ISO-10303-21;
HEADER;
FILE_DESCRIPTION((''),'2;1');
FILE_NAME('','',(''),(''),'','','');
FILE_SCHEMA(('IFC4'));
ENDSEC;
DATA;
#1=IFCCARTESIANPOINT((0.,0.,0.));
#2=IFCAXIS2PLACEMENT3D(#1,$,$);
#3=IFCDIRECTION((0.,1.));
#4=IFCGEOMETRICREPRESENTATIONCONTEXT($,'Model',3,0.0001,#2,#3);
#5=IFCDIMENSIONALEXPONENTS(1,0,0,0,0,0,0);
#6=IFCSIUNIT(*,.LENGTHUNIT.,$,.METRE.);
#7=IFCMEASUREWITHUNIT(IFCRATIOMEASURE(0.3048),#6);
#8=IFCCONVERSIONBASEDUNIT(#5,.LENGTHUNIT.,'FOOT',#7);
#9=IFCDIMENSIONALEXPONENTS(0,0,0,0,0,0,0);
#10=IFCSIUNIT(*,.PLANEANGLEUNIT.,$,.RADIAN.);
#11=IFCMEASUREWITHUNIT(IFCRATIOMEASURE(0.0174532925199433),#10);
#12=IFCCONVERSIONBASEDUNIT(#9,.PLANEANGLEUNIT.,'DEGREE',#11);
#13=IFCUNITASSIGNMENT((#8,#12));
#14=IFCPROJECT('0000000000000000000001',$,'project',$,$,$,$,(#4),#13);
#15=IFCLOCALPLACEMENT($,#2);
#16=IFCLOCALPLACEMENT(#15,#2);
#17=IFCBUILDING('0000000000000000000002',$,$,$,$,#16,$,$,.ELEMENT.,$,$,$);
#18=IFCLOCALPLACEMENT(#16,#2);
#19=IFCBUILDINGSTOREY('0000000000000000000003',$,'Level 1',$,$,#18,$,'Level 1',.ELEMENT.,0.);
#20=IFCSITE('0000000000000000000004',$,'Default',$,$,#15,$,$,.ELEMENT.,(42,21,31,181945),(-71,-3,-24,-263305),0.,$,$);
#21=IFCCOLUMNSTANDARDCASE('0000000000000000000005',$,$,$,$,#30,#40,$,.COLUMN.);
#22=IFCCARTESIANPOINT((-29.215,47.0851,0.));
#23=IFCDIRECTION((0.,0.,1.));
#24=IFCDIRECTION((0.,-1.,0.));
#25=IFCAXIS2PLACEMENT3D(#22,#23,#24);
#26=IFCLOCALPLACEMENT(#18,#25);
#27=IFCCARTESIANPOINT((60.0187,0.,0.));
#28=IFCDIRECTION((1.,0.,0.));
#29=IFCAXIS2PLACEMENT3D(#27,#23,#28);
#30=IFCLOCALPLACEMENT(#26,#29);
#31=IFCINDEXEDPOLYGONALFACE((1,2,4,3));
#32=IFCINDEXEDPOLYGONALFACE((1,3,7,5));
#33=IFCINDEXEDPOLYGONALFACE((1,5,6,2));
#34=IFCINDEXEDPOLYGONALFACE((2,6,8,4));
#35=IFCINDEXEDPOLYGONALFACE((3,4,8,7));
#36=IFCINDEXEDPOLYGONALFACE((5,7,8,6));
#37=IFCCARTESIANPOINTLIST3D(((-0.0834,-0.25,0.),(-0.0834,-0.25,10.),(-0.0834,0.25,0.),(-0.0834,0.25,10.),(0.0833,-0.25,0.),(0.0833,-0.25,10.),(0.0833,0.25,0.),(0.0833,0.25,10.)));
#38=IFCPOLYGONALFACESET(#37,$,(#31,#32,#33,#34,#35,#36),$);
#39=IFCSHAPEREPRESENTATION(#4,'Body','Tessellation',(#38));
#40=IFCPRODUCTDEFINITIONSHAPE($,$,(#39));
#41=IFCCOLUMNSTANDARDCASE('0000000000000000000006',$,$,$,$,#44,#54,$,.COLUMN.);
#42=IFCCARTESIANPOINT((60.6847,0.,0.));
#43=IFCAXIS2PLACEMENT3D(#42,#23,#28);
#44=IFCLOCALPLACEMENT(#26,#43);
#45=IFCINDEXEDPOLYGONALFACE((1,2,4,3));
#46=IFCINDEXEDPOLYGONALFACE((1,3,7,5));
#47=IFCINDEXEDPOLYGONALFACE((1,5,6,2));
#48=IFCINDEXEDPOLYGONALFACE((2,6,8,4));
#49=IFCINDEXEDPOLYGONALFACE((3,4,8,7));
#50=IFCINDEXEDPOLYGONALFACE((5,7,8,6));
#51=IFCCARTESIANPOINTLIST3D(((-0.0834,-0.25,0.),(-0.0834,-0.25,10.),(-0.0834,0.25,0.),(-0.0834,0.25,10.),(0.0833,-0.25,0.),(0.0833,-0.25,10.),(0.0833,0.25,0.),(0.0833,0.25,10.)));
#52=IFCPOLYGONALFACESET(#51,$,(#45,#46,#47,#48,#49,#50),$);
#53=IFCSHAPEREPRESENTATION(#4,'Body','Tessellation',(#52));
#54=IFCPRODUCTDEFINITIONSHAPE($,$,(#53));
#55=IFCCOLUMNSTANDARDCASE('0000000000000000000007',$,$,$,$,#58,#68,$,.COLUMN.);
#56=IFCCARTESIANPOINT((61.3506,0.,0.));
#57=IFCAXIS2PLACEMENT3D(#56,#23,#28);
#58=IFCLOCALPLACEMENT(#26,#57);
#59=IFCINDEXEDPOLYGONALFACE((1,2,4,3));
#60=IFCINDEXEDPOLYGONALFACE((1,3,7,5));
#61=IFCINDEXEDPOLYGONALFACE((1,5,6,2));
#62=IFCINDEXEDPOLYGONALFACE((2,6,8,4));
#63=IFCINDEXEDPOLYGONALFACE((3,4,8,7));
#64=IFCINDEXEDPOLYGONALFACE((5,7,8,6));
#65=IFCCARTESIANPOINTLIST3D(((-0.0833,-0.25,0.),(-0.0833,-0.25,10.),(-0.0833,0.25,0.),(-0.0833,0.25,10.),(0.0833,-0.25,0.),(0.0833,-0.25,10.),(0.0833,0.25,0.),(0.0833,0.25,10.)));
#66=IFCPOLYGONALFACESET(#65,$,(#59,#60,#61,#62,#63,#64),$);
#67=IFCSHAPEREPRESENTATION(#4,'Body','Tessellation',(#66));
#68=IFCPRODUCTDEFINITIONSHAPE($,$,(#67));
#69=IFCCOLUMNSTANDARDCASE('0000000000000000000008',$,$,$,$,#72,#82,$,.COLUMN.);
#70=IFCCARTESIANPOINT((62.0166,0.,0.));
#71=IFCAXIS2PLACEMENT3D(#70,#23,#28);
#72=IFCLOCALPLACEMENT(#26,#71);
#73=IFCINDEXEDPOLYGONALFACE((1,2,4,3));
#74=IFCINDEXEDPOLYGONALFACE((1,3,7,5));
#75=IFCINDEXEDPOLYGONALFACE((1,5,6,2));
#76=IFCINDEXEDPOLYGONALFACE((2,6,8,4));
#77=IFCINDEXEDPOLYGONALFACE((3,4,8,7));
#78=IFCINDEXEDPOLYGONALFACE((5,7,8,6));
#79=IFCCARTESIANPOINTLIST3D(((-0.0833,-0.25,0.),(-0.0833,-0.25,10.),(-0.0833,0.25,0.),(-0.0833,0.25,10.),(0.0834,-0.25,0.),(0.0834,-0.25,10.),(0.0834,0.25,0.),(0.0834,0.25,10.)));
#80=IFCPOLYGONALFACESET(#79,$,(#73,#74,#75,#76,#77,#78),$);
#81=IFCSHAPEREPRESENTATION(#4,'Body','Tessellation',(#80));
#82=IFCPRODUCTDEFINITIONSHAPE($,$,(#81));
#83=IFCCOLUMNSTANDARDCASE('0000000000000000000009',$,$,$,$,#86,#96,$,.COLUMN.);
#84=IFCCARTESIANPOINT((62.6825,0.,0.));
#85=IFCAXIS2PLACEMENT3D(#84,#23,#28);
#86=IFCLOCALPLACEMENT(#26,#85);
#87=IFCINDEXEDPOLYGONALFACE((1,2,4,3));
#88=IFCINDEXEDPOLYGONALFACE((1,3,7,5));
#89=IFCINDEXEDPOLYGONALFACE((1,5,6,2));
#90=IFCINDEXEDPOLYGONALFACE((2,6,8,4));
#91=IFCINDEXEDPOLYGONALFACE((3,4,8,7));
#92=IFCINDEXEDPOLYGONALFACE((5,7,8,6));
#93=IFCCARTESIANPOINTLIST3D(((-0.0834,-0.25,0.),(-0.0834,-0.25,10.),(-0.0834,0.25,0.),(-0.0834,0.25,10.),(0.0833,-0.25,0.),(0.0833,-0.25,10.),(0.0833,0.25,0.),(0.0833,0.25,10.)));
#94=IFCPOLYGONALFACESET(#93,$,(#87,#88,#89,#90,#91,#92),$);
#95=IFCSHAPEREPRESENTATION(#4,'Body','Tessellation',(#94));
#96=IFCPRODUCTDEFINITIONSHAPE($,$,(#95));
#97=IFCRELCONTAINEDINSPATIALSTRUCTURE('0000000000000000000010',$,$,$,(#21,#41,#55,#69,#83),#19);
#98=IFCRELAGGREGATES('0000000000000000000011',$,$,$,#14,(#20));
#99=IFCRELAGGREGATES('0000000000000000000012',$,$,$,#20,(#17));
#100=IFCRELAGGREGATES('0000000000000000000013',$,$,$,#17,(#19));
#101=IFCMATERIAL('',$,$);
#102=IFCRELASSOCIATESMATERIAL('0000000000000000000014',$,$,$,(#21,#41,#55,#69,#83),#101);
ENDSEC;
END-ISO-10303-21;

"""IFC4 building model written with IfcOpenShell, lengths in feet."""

from ifc_helpers import new_model, entity, si_unit, converted_unit, direction, frame, origin, place, context, project, spatial, rectangle, extrude, material, element, save


model = new_model("IFC4")

# Units and contexts
model_context = context("Model", 3, precision=0.0001, world=origin(), true_north=direction((0.0, 1.0)))
ifc_project = project(units=[converted_unit("LENGTHUNIT", "FOOT", entity("IfcRatioMeasure", 0.3048), si_unit("LENGTHUNIT", "METRE"), dimensions=[1, 0, 0, 0, 0, 0, 0]), converted_unit("PLANEANGLEUNIT", "DEGREE", entity("IfcRatioMeasure", 0.0174532925199433), si_unit("PLANEANGLEUNIT", "RADIAN"), dimensions=[0, 0, 0, 0, 0, 0, 0])], contexts=[model_context])

# Site, building, storey
site_placement = place(None, origin())
site = spatial("IfcSite", under=ifc_project, at=site_placement, Name="Default", CompositionType="ELEMENT", RefLatitude=(42, 21, 31, 181945), RefLongitude=(-71, -3, -24, -263305), RefElevation=0.0)
building_placement = place(site_placement, origin())
building = spatial("IfcBuilding", under=site, at=building_placement, CompositionType="ELEMENT")
storey_placement = place(building_placement, origin())
storey = spatial("IfcBuildingStorey", under=building, at=storey_placement, Name="Level 1", LongName="Level 1", CompositionType="ELEMENT", Elevation=0.0)

# Columns
ifc_material = material(Name="")
placement = place(storey_placement, frame((-29.215, 47.0851, 0.0), z_axis=(0.0, 0.0, 1.0), x_axis=(0.0, -1.0, 0.0)))
for number, where, z_axis, x_axis in (
    (1, (60.0187, 0.0, 0.0), (0.0, 0.0, 1.0), (1.0, 0.0, 0.0)),
    (2, (60.6847, 0.0, 0.0), (0.0, 0.0, 1.0), (1.0, 0.0, 0.0)),
    (3, (61.3506, 0.0, 0.0), (0.0, 0.0, 1.0), (1.0, 0.0, 0.0)),
    (4, (62.0166, 0.0, 0.0), (0.0, 0.0, 1.0), (1.0, 0.0, 0.0)),
    (5, (62.6825, 0.0, 0.0), (0.0, 0.0, 1.0), (1.0, 0.0, 0.0)),
):
    element("IfcColumnStandardCase", number, at=place(placement, frame(where, z_axis=z_axis, x_axis=x_axis)), inside=storey, material=ifc_material, PredefinedType="COLUMN", context=model_context, shape_type="SweptSolid", body=[
        extrude(rectangle(XDim=0.1667, YDim=0.5), origin(), (0.0, 0.0, 1.0), 10.0),
    ])

save(model, "model.ifc")
